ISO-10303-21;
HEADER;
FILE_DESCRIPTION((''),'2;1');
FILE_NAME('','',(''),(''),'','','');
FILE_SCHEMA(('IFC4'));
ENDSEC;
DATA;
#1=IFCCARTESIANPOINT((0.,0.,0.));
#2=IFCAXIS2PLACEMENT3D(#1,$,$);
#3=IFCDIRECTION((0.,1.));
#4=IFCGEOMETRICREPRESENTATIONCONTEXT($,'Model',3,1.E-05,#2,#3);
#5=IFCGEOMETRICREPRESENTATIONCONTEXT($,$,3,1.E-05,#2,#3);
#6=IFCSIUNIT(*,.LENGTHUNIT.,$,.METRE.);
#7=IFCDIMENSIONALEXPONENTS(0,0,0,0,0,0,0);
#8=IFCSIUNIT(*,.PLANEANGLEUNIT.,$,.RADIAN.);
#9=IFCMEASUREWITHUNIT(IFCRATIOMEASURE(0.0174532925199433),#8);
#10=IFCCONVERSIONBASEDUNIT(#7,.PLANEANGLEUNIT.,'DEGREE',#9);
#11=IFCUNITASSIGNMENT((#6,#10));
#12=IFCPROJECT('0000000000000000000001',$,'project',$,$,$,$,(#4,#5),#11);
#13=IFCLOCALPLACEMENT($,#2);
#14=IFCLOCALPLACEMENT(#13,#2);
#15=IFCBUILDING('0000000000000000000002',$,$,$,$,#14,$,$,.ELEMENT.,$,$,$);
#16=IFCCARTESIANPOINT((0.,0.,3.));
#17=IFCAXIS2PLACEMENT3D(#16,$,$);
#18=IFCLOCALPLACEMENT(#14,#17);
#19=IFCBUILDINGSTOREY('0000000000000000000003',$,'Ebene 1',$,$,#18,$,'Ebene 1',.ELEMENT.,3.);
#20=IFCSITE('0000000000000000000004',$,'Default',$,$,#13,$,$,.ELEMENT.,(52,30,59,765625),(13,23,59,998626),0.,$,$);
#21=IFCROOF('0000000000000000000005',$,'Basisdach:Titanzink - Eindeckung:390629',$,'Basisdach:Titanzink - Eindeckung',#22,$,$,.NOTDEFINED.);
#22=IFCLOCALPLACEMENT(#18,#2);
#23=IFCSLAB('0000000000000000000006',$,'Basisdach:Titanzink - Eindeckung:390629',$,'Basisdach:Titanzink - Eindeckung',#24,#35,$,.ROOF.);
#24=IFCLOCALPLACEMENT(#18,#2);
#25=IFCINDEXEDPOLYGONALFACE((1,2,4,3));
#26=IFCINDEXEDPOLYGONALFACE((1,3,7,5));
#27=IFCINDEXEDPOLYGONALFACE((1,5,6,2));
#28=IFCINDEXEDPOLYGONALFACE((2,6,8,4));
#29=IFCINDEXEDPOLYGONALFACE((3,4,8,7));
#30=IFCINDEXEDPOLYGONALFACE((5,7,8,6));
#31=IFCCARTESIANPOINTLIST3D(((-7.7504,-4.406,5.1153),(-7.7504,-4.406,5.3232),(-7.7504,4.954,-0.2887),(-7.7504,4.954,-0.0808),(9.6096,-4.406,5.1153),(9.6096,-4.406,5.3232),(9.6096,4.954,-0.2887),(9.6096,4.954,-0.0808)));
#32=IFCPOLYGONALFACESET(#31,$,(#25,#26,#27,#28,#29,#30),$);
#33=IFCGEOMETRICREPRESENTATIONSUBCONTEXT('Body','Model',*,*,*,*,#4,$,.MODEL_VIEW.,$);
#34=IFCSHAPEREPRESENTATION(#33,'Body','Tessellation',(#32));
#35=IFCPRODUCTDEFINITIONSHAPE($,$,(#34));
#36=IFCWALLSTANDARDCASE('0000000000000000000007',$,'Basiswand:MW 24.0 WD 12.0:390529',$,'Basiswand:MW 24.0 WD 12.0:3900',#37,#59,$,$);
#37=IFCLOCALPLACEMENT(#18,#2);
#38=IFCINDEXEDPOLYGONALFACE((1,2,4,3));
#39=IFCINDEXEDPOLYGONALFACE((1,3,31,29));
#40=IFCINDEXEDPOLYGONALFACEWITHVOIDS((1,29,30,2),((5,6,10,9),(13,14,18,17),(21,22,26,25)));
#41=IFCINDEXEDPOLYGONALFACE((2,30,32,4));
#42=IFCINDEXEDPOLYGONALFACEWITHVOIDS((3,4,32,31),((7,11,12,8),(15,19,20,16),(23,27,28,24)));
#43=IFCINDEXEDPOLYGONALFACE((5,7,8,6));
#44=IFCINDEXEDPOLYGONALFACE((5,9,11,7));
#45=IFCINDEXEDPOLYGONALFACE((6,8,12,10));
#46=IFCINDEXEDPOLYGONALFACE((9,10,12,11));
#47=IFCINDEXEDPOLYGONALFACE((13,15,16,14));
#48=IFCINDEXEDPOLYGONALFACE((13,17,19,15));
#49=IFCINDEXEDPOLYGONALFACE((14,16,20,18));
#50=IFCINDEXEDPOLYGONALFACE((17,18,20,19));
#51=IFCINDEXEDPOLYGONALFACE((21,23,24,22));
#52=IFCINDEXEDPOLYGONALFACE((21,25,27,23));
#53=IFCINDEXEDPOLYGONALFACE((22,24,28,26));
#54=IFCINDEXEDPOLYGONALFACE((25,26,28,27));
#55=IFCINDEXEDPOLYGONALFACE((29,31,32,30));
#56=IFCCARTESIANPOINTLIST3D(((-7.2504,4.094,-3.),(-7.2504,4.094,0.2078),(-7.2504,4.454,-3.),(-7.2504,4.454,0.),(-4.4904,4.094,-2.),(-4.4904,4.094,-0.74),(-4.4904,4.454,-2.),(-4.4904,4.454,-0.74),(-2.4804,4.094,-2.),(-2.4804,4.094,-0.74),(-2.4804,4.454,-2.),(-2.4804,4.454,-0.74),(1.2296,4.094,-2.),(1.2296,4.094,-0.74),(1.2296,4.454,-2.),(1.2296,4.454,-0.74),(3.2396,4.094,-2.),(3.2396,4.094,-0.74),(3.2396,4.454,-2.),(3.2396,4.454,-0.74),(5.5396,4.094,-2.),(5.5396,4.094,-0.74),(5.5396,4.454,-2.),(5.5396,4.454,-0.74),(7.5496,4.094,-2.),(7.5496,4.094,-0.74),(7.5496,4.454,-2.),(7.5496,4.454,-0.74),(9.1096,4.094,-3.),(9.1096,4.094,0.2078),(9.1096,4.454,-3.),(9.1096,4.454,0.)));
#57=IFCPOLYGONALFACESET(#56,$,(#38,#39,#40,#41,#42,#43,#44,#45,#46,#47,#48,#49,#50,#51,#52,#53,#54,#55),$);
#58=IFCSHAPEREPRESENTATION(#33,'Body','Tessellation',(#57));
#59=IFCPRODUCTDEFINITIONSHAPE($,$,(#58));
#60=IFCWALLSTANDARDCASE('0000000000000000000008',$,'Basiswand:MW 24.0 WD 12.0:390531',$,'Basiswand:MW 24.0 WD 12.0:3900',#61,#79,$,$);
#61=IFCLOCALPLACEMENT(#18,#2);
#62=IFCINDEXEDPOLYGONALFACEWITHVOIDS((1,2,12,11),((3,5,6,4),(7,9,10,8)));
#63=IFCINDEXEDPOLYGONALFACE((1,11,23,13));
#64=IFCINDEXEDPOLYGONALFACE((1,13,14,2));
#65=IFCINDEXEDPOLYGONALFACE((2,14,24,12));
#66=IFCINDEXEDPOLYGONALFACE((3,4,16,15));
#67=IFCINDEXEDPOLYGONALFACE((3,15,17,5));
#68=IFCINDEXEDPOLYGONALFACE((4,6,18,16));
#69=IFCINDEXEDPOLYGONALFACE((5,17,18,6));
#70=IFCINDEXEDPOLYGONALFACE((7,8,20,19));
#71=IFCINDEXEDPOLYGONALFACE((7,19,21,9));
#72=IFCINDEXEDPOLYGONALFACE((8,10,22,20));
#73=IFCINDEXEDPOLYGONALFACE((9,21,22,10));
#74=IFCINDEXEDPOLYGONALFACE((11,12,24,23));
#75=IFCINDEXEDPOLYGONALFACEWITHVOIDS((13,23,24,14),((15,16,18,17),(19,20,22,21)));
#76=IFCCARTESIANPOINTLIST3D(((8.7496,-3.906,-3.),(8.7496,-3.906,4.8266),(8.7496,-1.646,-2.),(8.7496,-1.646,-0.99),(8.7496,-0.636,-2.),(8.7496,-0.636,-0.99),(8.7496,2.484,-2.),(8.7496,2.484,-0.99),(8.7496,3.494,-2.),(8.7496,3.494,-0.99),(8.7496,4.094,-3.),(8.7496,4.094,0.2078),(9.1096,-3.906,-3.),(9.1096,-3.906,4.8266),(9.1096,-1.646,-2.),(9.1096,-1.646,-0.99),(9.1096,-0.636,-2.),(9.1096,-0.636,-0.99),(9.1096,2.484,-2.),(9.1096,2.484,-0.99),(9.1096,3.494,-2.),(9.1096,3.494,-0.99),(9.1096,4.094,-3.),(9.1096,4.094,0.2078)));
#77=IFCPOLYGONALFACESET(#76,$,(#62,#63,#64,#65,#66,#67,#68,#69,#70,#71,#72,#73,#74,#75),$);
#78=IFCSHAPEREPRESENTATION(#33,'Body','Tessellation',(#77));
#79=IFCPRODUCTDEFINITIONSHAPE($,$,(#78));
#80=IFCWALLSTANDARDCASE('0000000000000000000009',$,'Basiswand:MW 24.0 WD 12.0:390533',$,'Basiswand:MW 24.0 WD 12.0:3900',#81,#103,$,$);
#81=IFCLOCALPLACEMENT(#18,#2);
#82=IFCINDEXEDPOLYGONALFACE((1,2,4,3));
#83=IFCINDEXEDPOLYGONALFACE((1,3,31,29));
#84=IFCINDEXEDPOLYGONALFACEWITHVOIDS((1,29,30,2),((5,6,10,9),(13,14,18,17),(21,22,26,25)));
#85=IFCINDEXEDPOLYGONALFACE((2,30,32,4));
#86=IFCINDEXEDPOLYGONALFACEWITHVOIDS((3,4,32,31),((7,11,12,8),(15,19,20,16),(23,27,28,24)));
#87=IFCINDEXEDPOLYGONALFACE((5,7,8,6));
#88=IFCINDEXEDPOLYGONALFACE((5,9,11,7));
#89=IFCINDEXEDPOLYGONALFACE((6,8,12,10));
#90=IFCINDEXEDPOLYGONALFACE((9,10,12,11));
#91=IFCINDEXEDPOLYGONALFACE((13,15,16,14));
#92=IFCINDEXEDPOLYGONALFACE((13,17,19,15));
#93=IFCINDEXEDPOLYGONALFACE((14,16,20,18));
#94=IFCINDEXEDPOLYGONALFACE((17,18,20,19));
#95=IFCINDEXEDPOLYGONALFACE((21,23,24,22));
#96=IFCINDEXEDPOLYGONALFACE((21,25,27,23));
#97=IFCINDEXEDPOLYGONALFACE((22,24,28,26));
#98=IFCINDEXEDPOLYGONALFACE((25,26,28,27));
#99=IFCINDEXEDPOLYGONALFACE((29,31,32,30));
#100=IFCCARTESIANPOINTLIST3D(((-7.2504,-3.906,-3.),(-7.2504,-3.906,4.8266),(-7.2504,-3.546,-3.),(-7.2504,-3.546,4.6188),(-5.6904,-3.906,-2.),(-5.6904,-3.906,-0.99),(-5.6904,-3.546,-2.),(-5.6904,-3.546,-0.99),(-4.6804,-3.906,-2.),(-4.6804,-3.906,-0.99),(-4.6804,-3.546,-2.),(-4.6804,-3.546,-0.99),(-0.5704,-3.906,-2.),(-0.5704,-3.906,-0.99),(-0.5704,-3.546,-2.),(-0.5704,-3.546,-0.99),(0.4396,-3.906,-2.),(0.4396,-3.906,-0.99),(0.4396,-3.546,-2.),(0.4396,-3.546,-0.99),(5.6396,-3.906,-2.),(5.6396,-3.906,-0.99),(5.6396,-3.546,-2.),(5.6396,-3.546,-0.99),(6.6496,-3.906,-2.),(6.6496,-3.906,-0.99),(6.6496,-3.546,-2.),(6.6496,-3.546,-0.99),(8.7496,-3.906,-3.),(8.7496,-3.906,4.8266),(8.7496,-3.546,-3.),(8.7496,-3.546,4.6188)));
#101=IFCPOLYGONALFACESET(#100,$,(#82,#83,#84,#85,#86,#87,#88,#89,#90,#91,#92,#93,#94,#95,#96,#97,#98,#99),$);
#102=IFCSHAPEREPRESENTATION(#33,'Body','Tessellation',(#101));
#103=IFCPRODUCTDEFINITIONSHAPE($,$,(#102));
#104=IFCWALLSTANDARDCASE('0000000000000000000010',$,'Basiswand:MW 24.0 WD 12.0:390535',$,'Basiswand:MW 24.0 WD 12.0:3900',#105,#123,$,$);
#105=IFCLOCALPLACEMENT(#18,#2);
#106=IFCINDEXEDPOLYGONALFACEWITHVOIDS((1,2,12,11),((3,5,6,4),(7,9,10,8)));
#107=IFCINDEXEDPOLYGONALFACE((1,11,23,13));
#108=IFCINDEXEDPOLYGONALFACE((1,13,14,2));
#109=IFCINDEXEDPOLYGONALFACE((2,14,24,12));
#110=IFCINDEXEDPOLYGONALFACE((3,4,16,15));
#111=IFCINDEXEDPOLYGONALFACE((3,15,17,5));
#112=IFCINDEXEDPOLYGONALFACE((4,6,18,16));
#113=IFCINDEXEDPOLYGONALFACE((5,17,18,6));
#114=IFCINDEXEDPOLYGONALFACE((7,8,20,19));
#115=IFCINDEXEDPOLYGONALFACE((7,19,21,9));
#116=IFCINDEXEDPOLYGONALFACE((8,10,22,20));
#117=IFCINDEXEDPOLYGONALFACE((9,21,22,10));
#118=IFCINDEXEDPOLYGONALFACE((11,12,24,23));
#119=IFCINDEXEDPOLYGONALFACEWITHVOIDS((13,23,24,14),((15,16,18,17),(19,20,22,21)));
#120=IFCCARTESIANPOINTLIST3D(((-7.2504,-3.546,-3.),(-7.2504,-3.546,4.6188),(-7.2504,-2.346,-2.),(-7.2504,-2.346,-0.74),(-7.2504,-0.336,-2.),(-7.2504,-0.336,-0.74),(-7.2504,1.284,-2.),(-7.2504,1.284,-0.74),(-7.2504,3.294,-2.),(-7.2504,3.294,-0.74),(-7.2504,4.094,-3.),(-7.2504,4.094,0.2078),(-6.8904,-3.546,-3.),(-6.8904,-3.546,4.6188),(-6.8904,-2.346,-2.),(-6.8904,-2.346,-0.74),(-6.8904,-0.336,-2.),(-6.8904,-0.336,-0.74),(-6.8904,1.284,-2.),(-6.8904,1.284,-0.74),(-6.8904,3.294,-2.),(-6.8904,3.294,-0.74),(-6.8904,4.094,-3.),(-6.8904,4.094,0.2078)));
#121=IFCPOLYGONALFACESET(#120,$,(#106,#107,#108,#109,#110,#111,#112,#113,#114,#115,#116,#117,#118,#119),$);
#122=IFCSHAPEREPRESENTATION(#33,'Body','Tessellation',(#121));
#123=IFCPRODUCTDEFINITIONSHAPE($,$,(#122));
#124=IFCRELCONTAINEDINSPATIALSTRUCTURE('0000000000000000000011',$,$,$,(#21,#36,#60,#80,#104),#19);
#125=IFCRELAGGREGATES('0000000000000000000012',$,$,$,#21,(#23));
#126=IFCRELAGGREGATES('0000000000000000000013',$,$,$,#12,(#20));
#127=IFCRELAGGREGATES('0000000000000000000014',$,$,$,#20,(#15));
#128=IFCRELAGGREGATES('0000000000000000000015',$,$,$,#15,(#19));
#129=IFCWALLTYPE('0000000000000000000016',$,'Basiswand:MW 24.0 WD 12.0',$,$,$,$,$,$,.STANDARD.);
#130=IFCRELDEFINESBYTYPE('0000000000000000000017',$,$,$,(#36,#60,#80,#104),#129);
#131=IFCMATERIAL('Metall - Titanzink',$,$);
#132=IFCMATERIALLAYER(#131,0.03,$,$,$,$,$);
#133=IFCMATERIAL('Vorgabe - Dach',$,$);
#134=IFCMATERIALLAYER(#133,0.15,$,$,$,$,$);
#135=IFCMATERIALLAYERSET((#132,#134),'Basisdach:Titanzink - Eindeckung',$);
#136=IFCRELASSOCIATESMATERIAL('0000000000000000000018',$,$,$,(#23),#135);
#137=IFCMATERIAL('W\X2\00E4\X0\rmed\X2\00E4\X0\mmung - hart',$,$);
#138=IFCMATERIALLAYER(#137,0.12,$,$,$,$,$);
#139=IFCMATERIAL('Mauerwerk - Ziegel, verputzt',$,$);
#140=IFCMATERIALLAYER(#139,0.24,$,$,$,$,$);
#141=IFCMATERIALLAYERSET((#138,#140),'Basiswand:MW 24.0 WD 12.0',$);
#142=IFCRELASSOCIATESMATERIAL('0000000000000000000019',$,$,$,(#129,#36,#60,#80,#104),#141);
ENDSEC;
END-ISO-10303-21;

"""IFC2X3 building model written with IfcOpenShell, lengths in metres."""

from ifc_helpers import new_model, entity, si_unit, converted_unit, direction, frame, frame_2d, origin, place, context, subcontext, project, spatial, polyline, rectangle, extrude, clip, bounded_halfspace, material, layer, layer_set, layer_usage, type_object, element, aggregate, save


model = new_model("IFC2X3")

# Units and contexts
model_context = context("Model", 3, precision=1e-05, world=origin(), true_north=direction((0.0, 1.0)))
context_of_model = context(None, 3, precision=1e-05, world=origin(), true_north=direction((0.0, 1.0)))
body_context = subcontext(model_context, "Body", "Model", "MODEL_VIEW")
ifc_project = project(units=[si_unit("LENGTHUNIT", "METRE"), converted_unit("PLANEANGLEUNIT", "DEGREE", entity("IfcRatioMeasure", 0.0174532925199433), si_unit("PLANEANGLEUNIT", "RADIAN"), dimensions=[0, 0, 0, 0, 0, 0, 0])], contexts=[model_context, context_of_model])

# Site, building, storey
site_placement = place(None, origin())
site = spatial("IfcSite", under=ifc_project, at=site_placement, Name="Default", CompositionType="ELEMENT", RefLatitude=(52, 30, 59, 765625), RefLongitude=(13, 23, 59, 998626), RefElevation=0.0)
building_placement = place(site_placement, origin())
building = spatial("IfcBuilding", under=site, at=building_placement, CompositionType="ELEMENT")
storey_placement = place(building_placement, frame((0.0, 0.0, 3.0)))
storey = spatial("IfcBuildingStorey", under=building, at=storey_placement, Name="Ebene 1", LongName="Ebene 1", CompositionType="ELEMENT", Elevation=3.0)

# Roof, slab
roof_placement = place(storey_placement, frame((-7.7504, -4.406, -0.2887)))
roof = element("IfcRoof", 1, at=roof_placement, inside=storey, Name="Basisdach:Titanzink - Eindeckung:390629", ObjectType="Basisdach:Titanzink - Eindeckung", ShapeType="NOTDEFINED")
ifc_material_1 = material(Name="Metall - Titanzink")
ifc_layer_1 = layer(ifc_material_1, 0.03)
ifc_material_2 = material(Name="Vorgabe - Dach")
ifc_layer_2 = layer(ifc_material_2, 0.15)
ifc_layer_set_1 = layer_set([ifc_layer_1, ifc_layer_2], Name="Basisdach:Titanzink - Eindeckung")
slab_placement = place(roof_placement, origin())
slab = element("IfcSlab", 2, at=slab_placement, material=ifc_layer_set_1, Name="Basisdach:Titanzink - Eindeckung:390629", ObjectType="Basisdach:Titanzink - Eindeckung", PredefinedType="ROOF", context=body_context, shape_type="SweptSolid", body=[
    extrude(rectangle(XDim=17.36, YDim=10.808, at=frame_2d((0.0, 0.0), x_axis=(1.0, 0.0))), frame((8.68, 4.68, 2.702), z_axis=(0.0, 0.5, 0.866025), x_axis=(1.0, 0.0, 0.0)), (0.0, -0.5, 0.866025), 0.2078),
])
aggregate(roof, [slab])

# Walls, openings
ifc_material_3 = material(Name="Wärmedämmung - hart")
ifc_layer_3 = layer(ifc_material_3, 0.12)
ifc_material_4 = material(Name="Mauerwerk - Ziegel, verputzt")
ifc_layer_4 = layer(ifc_material_4, 0.24)
ifc_layer_set_2 = layer_set([ifc_layer_3, ifc_layer_4], Name="Basiswand:MW 24.0 WD 12.0")
ifc_layer_usage_1 = layer_usage(ifc_layer_set_2, "AXIS2", "NEGATIVE", 0.18)
wall_type = type_object("IfcWallType", Name="Basiswand:MW 24.0 WD 12.0", PredefinedType="STANDARD", material=ifc_layer_set_2)
wall_1_placement = place(storey_placement, frame((-7.2504, 4.274, -3.0)))
wall_1 = element("IfcWallStandardCase", 3, at=wall_1_placement, inside=storey, type_object=wall_type, material=ifc_layer_usage_1, Name="Basiswand:MW 24.0 WD 12.0:390529", ObjectType="Basiswand:MW 24.0 WD 12.0:3900", context=body_context, shape_type="Clipping", body=[
    clip(extrude(rectangle(XDim=16.36, YDim=0.36, at=frame_2d((8.18, 0.0), x_axis=(-1.0, 0.0))), origin(), (0.0, 0.0, 1.0), 3.2078), bounded_halfspace(frame((0.0, -0.18, 3.2078), z_axis=(0.0, 0.5, 0.866025), x_axis=(-1.0, 0.0, 0.0)), False, frame((0.0, -0.18, 3.2078)), polyline([(0.0, 0.0), (0.36, 0.0), (16.0, 0.0), (16.36, 0.0), (16.36, 0.36), (0.0, 0.36), (0.0, 0.0)]))),
])
opening_1_placement = place(wall_1_placement, frame((12.79, -0.18, 1.0)))
element("IfcOpeningElement", 4, at=opening_1_placement, cuts=wall_1, ObjectType="Opening", context=body_context, shape_type="SweptSolid", body=[
    extrude(rectangle(XDim=1.26, YDim=2.01, at=frame_2d((0.63, 1.005), x_axis=(1.0, 0.0))), frame((0.0, 0.0, 0.0), z_axis=(0.0, 1.0, 0.0), x_axis=(0.0, 0.0, 1.0)), (0.0, 0.0, 1.0), 0.36),
])
opening_2_placement = place(wall_1_placement, frame((8.48, -0.18, 1.0)))
element("IfcOpeningElement", 5, at=opening_2_placement, cuts=wall_1, ObjectType="Opening", context=body_context, shape_type="SweptSolid", body=[
    extrude(rectangle(XDim=1.26, YDim=2.01, at=frame_2d((0.63, 1.005), x_axis=(1.0, 0.0))), frame((0.0, 0.0, 0.0), z_axis=(0.0, 1.0, 0.0), x_axis=(0.0, 0.0, 1.0)), (0.0, 0.0, 1.0), 0.36),
])
opening_3_placement = place(wall_1_placement, frame((2.76, -0.18, 1.0)))
element("IfcOpeningElement", 6, at=opening_3_placement, cuts=wall_1, ObjectType="Opening", context=body_context, shape_type="SweptSolid", body=[
    extrude(rectangle(XDim=1.26, YDim=2.01, at=frame_2d((0.63, 1.005), x_axis=(1.0, 0.0))), frame((0.0, 0.0, 0.0), z_axis=(0.0, 1.0, 0.0), x_axis=(0.0, 0.0, 1.0)), (0.0, 0.0, 1.0), 0.36),
])
ifc_layer_usage_2 = layer_usage(ifc_layer_set_2, "AXIS2", "NEGATIVE", 0.18)
wall_2_placement = place(storey_placement, frame((8.9296, 4.094, -3.0), z_axis=(0.0, 0.0, 1.0), x_axis=(0.0, -1.0, 0.0)))
wall_2 = element("IfcWallStandardCase", 7, at=wall_2_placement, inside=storey, type_object=wall_type, material=ifc_layer_usage_2, Name="Basiswand:MW 24.0 WD 12.0:390531", ObjectType="Basiswand:MW 24.0 WD 12.0:3900", context=body_context, shape_type="Clipping", body=[
    clip(extrude(rectangle(XDim=8.0, YDim=0.36, at=frame_2d((4.0, 0.0), x_axis=(-1.0, 0.0))), origin(), (0.0, 0.0, 1.0), 7.8266), bounded_halfspace(frame((0.0, -0.18, 3.2078), z_axis=(-0.5, 0.0, 0.866025), x_axis=(0.0, -1.0, 0.0)), False, frame((0.0, -0.18, 3.2078)), polyline([(0.0, 0.0), (7.64, 0.0), (8.0, 0.0), (8.0, 0.36), (0.0, 0.36), (0.0, 0.0)]))),
])
opening_4_placement = place(wall_2_placement, frame((0.6, -0.18, 1.0)))
element("IfcOpeningElement", 8, at=opening_4_placement, cuts=wall_2, ObjectType="Opening", context=body_context, shape_type="SweptSolid", body=[
    extrude(rectangle(XDim=1.01, YDim=1.01, at=frame_2d((0.505, 0.505), x_axis=(1.0, 0.0))), frame((0.0, 0.0, 0.0), z_axis=(0.0, 1.0, 0.0), x_axis=(0.0, 0.0, 1.0)), (0.0, 0.0, 1.0), 0.36),
])
opening_5_placement = place(wall_2_placement, frame((4.73, -0.18, 1.0)))
element("IfcOpeningElement", 9, at=opening_5_placement, cuts=wall_2, ObjectType="Opening", context=body_context, shape_type="SweptSolid", body=[
    extrude(rectangle(XDim=1.01, YDim=1.01, at=frame_2d((0.505, 0.505), x_axis=(1.0, 0.0))), frame((0.0, 0.0, 0.0), z_axis=(0.0, 1.0, 0.0), x_axis=(0.0, 0.0, 1.0)), (0.0, 0.0, 1.0), 0.36),
])
ifc_layer_usage_3 = layer_usage(ifc_layer_set_2, "AXIS2", "NEGATIVE", 0.18)
wall_3_placement = place(storey_placement, frame((8.7496, -3.726, -3.0), z_axis=(0.0, 0.0, 1.0), x_axis=(-1.0, 0.0, 0.0)))
wall_3 = element("IfcWallStandardCase", 10, at=wall_3_placement, inside=storey, type_object=wall_type, material=ifc_layer_usage_3, Name="Basiswand:MW 24.0 WD 12.0:390533", ObjectType="Basiswand:MW 24.0 WD 12.0:3900", context=body_context, shape_type="Clipping", body=[
    clip(extrude(rectangle(XDim=16.0, YDim=0.36, at=frame_2d((8.0, 0.0), x_axis=(-1.0, 0.0))), origin(), (0.0, 0.0, 1.0), 7.8266), bounded_halfspace(frame((0.0, -0.18, 7.6188), z_axis=(0.0, -0.5, 0.866025), x_axis=(1.0, 0.0, 0.0)), False, frame((0.0, -0.18, 7.6188)), polyline([(0.0, 0.0), (15.64, 0.0), (16.0, 0.0), (16.0, 0.36), (0.0, 0.36), (0.0, 0.0)]))),
])
opening_6_placement = place(wall_3_placement, frame((2.1, -0.18, 1.0)))
element("IfcOpeningElement", 11, at=opening_6_placement, cuts=wall_3, ObjectType="Opening", context=body_context, shape_type="SweptSolid", body=[
    extrude(rectangle(XDim=1.01, YDim=1.01, at=frame_2d((0.505, 0.505), x_axis=(1.0, 0.0))), frame((0.0, 0.0, 0.0), z_axis=(0.0, 1.0, 0.0), x_axis=(0.0, 0.0, 1.0)), (0.0, 0.0, 1.0), 0.36),
])
opening_7_placement = place(wall_3_placement, frame((8.31, -0.18, 1.0)))
element("IfcOpeningElement", 12, at=opening_7_placement, cuts=wall_3, ObjectType="Opening", context=body_context, shape_type="SweptSolid", body=[
    extrude(rectangle(XDim=1.01, YDim=1.01, at=frame_2d((0.505, 0.505), x_axis=(1.0, 0.0))), frame((0.0, 0.0, 0.0), z_axis=(0.0, 1.0, 0.0), x_axis=(0.0, 0.0, 1.0)), (0.0, 0.0, 1.0), 0.36),
])
opening_8_placement = place(wall_3_placement, frame((13.43, -0.18, 1.0)))
element("IfcOpeningElement", 13, at=opening_8_placement, cuts=wall_3, ObjectType="Opening", context=body_context, shape_type="SweptSolid", body=[
    extrude(rectangle(XDim=1.01, YDim=1.01, at=frame_2d((0.505, 0.505), x_axis=(1.0, 0.0))), frame((0.0, 0.0, 0.0), z_axis=(0.0, 1.0, 0.0), x_axis=(0.0, 0.0, 1.0)), (0.0, 0.0, 1.0), 0.36),
])
ifc_layer_usage_4 = layer_usage(ifc_layer_set_2, "AXIS2", "NEGATIVE", 0.18)
wall_4_placement = place(storey_placement, frame((-7.0704, -3.546, -3.0), z_axis=(0.0, 0.0, 1.0), x_axis=(0.0, 1.0, 0.0)))
wall_4 = element("IfcWallStandardCase", 14, at=wall_4_placement, inside=storey, type_object=wall_type, material=ifc_layer_usage_4, Name="Basiswand:MW 24.0 WD 12.0:390535", ObjectType="Basiswand:MW 24.0 WD 12.0:3900", context=body_context, shape_type="Clipping", body=[
    clip(extrude(rectangle(XDim=7.64, YDim=0.36, at=frame_2d((3.82, 0.0), x_axis=(-1.0, 0.0))), origin(), (0.0, 0.0, 1.0), 7.6188), bounded_halfspace(frame((0.0, -0.18, 7.6188), z_axis=(0.5, 0.0, 0.866025), x_axis=(0.0, 1.0, 0.0)), False, frame((0.0, -0.18, 7.6188)), polyline([(0.0, 0.0), (7.64, 0.0), (7.64, 0.36), (0.0, 0.36), (0.0, 0.0)]))),
])
opening_9_placement = place(wall_4_placement, frame((4.83, -0.18, 1.0)))
element("IfcOpeningElement", 15, at=opening_9_placement, cuts=wall_4, ObjectType="Opening", context=body_context, shape_type="SweptSolid", body=[
    extrude(rectangle(XDim=1.26, YDim=2.01, at=frame_2d((0.63, 1.005), x_axis=(1.0, 0.0))), frame((0.0, 0.0, 0.0), z_axis=(0.0, 1.0, 0.0), x_axis=(0.0, 0.0, 1.0)), (0.0, 0.0, 1.0), 0.36),
])
opening_10_placement = place(wall_4_placement, frame((1.2, -0.18, 1.0)))
element("IfcOpeningElement", 16, at=opening_10_placement, cuts=wall_4, ObjectType="Opening", context=body_context, shape_type="SweptSolid", body=[
    extrude(rectangle(XDim=1.26, YDim=2.01, at=frame_2d((0.63, 1.005), x_axis=(1.0, 0.0))), frame((0.0, 0.0, 0.0), z_axis=(0.0, 1.0, 0.0), x_axis=(0.0, 0.0, 1.0)), (0.0, 0.0, 1.0), 0.36),
])

save(model, "model.ifc")
